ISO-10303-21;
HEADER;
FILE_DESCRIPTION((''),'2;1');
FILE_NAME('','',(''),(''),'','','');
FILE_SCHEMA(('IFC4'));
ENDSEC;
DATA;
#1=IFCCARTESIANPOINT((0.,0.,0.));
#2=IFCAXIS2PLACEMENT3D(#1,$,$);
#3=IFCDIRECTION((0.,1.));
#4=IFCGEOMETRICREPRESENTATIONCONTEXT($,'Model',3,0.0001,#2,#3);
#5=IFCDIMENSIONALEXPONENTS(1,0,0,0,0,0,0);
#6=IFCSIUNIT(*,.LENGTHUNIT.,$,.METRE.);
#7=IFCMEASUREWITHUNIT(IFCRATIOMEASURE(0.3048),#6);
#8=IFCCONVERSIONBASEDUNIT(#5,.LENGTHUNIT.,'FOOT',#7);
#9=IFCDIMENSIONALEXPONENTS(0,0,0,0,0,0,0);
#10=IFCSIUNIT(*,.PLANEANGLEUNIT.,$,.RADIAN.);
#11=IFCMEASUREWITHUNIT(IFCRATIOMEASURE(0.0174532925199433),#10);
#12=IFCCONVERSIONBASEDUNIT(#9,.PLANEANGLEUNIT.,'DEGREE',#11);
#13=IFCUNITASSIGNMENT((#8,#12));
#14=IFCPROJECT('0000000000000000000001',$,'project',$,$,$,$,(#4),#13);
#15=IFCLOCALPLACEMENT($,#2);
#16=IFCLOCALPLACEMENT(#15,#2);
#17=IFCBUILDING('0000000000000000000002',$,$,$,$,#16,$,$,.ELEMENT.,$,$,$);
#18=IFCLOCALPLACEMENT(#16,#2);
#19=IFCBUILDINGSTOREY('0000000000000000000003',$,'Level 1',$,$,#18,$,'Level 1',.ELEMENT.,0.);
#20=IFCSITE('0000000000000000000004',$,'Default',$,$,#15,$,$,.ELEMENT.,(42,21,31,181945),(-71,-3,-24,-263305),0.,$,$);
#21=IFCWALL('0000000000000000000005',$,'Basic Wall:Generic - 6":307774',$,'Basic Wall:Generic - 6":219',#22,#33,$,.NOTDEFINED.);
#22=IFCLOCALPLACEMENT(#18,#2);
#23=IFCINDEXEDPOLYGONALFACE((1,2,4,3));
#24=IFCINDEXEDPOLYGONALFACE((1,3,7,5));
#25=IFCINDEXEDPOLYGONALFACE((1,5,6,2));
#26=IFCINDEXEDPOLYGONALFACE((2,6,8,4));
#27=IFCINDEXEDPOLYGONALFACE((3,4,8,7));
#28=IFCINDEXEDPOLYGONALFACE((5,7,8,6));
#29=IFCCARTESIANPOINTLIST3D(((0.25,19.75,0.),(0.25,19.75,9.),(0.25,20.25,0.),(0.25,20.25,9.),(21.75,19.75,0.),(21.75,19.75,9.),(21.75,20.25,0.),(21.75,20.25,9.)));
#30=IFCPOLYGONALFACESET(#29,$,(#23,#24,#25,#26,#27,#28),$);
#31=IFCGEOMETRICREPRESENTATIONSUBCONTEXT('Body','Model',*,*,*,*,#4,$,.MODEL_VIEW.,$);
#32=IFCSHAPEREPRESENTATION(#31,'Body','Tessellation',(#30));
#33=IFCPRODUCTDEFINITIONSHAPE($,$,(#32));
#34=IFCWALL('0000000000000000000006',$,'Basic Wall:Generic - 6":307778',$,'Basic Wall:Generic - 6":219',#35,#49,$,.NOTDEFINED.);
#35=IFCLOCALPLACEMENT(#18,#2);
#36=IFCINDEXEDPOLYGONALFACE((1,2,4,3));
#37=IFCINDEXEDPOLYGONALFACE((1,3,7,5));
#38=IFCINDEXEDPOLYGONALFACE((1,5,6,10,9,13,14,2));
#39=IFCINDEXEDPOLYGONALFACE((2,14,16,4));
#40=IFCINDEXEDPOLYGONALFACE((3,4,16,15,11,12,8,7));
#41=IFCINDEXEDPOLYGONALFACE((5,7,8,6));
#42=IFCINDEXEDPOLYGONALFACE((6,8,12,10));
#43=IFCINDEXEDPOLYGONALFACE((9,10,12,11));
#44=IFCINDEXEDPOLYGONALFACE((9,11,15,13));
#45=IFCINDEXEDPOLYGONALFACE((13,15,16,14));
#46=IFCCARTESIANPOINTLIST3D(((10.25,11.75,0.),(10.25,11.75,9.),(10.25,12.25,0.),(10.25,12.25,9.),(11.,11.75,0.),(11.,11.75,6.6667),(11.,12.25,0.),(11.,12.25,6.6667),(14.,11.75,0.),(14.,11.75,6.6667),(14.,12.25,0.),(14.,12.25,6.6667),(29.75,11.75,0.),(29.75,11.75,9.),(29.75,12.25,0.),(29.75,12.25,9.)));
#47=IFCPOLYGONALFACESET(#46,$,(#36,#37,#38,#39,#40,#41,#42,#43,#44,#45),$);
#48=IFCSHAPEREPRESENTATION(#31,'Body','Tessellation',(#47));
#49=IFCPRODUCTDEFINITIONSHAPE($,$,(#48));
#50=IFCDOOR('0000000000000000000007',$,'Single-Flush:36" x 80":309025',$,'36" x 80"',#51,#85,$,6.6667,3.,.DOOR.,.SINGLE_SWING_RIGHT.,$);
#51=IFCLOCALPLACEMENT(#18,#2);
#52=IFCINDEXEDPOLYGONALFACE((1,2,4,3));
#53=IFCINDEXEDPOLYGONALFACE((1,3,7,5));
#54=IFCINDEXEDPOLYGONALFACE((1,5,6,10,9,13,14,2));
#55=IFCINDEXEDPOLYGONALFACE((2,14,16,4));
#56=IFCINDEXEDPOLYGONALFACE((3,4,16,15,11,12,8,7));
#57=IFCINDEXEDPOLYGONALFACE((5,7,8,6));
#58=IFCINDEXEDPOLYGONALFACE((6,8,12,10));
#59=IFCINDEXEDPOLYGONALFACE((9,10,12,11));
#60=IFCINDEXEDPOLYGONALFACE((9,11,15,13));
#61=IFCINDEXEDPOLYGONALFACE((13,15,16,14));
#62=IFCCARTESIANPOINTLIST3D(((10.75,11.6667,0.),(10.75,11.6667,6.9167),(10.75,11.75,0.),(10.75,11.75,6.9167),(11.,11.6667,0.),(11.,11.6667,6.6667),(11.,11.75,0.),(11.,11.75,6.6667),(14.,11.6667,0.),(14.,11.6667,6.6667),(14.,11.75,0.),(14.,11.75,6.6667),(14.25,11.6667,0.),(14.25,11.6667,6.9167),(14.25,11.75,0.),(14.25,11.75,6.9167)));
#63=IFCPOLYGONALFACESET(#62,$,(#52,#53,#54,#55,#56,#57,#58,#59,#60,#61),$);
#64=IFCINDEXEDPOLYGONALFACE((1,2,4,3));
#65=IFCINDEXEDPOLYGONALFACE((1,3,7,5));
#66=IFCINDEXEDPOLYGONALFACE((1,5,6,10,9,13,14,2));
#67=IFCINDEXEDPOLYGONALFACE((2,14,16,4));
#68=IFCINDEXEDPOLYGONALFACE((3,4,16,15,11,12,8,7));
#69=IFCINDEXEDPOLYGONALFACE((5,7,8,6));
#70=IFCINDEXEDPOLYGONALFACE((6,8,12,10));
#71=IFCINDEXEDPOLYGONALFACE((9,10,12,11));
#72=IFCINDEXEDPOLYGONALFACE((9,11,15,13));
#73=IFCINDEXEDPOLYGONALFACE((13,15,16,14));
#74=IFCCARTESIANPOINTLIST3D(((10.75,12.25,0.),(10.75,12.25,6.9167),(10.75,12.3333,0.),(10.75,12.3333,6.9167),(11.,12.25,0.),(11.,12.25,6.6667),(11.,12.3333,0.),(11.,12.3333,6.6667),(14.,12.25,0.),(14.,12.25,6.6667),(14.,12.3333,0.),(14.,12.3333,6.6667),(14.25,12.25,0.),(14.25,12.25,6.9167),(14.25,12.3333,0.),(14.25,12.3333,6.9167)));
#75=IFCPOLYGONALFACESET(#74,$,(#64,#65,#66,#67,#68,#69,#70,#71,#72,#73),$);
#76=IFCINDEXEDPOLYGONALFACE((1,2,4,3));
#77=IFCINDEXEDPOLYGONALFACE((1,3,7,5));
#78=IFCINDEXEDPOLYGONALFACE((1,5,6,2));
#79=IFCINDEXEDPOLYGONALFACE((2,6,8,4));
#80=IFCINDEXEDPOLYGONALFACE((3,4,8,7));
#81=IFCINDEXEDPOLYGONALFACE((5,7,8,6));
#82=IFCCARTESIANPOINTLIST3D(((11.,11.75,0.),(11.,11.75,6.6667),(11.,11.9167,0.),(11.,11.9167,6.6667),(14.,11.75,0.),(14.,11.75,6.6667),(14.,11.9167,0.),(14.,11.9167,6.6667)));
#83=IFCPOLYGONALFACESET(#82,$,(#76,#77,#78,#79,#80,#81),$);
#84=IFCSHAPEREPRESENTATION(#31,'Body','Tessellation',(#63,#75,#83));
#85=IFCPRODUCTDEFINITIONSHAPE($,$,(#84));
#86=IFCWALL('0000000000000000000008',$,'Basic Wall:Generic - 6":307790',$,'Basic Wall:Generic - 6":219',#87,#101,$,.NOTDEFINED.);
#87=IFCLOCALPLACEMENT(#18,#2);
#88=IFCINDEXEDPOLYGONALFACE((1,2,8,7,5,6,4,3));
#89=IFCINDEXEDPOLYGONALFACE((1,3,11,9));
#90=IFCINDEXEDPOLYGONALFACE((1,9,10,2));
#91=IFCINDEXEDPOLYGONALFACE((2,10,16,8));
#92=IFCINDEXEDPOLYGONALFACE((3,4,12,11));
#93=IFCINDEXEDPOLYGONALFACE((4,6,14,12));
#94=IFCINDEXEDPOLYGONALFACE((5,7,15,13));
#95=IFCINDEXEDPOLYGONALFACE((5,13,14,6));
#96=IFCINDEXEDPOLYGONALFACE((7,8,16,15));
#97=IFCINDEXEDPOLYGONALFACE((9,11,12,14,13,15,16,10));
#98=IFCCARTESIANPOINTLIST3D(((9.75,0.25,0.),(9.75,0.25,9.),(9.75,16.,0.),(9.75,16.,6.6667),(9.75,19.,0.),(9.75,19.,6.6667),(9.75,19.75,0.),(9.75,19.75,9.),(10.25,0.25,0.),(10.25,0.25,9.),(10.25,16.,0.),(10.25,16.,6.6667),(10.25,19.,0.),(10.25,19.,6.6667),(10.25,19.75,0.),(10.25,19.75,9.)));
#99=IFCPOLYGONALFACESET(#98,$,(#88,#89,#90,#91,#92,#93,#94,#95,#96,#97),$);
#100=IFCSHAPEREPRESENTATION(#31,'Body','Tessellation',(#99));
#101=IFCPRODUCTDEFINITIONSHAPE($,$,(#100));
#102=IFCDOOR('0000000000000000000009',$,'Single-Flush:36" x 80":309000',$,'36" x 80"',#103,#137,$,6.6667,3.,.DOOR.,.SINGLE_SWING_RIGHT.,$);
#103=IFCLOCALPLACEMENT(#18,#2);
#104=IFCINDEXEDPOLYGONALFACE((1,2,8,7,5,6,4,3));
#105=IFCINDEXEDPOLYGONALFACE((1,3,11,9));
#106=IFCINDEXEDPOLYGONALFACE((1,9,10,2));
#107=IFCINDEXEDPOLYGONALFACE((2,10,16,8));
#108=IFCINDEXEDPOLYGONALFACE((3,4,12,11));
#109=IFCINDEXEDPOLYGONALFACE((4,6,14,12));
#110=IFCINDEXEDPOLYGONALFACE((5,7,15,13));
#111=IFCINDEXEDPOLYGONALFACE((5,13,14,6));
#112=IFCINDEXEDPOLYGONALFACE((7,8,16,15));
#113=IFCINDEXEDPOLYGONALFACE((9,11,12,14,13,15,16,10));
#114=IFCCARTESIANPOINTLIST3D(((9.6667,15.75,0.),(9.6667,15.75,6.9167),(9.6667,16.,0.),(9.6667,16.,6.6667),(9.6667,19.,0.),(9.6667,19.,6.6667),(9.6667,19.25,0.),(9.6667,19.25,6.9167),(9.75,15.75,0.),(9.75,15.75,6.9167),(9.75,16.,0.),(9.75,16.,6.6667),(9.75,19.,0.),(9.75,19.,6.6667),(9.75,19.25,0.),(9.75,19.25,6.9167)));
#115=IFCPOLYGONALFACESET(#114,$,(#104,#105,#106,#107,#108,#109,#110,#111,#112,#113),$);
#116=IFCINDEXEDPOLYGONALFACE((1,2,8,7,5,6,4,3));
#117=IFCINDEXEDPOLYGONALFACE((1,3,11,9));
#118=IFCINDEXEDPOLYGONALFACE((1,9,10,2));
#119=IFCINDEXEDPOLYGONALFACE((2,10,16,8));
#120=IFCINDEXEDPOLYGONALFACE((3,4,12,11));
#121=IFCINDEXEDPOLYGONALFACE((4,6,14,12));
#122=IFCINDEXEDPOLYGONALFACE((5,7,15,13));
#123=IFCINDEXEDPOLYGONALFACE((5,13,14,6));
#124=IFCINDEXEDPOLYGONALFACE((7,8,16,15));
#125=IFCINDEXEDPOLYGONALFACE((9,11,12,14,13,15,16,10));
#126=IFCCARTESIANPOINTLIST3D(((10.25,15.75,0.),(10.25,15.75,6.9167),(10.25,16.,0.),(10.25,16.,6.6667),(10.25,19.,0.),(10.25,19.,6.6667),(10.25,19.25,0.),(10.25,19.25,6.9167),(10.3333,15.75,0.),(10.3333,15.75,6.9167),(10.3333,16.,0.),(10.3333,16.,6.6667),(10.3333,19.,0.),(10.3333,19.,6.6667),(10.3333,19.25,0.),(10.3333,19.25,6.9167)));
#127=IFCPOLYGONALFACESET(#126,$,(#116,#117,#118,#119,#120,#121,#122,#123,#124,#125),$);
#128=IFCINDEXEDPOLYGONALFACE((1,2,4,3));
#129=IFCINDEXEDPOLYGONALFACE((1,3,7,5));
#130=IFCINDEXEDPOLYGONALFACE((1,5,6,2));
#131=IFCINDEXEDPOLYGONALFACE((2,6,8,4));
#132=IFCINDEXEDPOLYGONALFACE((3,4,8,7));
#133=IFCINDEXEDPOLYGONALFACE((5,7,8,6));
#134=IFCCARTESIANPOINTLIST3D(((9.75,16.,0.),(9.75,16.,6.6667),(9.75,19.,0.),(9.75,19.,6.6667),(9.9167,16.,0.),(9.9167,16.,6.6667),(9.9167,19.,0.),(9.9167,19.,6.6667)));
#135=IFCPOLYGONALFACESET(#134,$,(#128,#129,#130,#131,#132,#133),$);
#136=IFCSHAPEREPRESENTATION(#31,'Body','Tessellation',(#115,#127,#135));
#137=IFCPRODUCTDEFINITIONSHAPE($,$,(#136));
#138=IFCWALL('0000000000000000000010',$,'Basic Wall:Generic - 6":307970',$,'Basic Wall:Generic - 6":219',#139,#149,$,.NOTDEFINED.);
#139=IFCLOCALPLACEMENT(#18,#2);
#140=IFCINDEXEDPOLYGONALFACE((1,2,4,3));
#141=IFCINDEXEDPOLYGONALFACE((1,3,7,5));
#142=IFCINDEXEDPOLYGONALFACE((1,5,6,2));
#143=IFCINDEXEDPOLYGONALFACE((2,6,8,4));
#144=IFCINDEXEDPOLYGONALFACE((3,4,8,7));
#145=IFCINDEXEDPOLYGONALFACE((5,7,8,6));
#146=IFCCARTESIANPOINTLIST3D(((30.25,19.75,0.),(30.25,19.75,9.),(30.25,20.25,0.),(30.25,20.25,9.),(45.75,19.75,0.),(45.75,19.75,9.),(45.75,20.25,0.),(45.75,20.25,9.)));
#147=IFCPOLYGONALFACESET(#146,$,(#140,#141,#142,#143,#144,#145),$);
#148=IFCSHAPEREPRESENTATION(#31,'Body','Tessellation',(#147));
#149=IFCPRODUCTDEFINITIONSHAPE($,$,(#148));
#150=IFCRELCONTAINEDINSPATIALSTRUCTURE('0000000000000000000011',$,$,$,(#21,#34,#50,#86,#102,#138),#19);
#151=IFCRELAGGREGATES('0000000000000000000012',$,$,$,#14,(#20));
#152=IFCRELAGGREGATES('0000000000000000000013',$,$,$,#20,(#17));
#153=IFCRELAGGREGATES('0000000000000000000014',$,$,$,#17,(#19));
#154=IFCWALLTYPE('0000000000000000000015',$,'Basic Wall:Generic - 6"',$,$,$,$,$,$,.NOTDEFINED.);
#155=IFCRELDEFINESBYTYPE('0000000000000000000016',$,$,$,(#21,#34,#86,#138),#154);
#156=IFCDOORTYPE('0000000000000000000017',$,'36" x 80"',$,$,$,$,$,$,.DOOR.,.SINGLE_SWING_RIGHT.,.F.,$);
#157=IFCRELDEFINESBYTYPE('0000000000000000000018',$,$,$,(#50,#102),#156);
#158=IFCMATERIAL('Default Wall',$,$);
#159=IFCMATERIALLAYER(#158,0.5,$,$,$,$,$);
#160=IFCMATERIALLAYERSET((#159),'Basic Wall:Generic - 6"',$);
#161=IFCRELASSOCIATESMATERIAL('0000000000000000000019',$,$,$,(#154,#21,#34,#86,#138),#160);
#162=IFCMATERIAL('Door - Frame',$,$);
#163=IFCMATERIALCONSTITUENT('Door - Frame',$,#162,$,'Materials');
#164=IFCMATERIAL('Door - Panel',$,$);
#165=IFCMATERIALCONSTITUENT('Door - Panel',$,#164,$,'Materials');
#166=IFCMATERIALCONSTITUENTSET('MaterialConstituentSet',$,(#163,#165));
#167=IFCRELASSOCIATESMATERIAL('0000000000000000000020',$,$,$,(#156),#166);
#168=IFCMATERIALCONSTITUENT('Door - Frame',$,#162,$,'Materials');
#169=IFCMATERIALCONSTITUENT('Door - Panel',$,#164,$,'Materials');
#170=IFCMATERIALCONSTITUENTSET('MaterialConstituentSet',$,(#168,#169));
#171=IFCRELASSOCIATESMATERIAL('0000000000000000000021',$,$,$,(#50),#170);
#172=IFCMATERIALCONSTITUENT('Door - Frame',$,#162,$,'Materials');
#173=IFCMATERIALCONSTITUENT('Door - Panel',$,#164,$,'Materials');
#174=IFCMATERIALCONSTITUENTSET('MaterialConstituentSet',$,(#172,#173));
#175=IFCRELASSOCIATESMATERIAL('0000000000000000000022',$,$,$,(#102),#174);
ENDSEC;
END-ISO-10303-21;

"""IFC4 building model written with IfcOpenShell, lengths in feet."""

from ifc_helpers import new_model, entity, si_unit, converted_unit, direction, frame, frame_2d, origin, origin_2d_with_axis, place, context, subcontext, project, spatial, polyline, rectangle, outline, extrude, clip, bounded_halfspace, source, transform, mapped, material, layer, layer_set, layer_usage, constituent, constituent_set, type_object, type_shapes, element, fill, save


model = new_model("IFC4")

# Units and contexts
model_context = context("Model", 3, precision=0.0001, world=origin(), true_north=direction((0.0, 1.0)))
body_context = subcontext(model_context, "Body", "Model", "MODEL_VIEW")
ifc_project = project(units=[converted_unit("LENGTHUNIT", "FOOT", entity("IfcRatioMeasure", 0.3048), si_unit("LENGTHUNIT", "METRE"), dimensions=[1, 0, 0, 0, 0, 0, 0]), converted_unit("PLANEANGLEUNIT", "DEGREE", entity("IfcRatioMeasure", 0.0174532925199433), si_unit("PLANEANGLEUNIT", "RADIAN"), dimensions=[0, 0, 0, 0, 0, 0, 0])], contexts=[model_context])

# Site, building, storey
site_placement = place(None, origin())
site = spatial("IfcSite", under=ifc_project, at=site_placement, Name="Default", CompositionType="ELEMENT", RefLatitude=(42, 21, 31, 181945), RefLongitude=(-71, -3, -24, -263305), RefElevation=0.0)
building_placement = place(site_placement, origin())
building = spatial("IfcBuilding", under=site, at=building_placement, CompositionType="ELEMENT")
storey_placement = place(building_placement, origin())
storey = spatial("IfcBuildingStorey", under=building, at=storey_placement, Name="Level 1", LongName="Level 1", CompositionType="ELEMENT", Elevation=0.0)

# Shared definitions
ifc_material_1 = material(Name="Default Wall")
ifc_layer = layer(ifc_material_1, 0.5)
ifc_layer_set = layer_set([ifc_layer], Name="Basic Wall:Generic - 6\"")
wall_type = type_object("IfcWallType", Name="Basic Wall:Generic - 6\"", PredefinedType="NOTDEFINED", material=ifc_layer_set)

# Wall
ifc_layer_usage_1 = layer_usage(ifc_layer_set, "AXIS2", "NEGATIVE", 0.25)
wall_1_placement = place(storey_placement, frame((0.25, 20.0, 0.0)))
element("IfcWall", 1, at=wall_1_placement, inside=storey, type_object=wall_type, material=ifc_layer_usage_1, Name="Basic Wall:Generic - 6\":307774", ObjectType="Basic Wall:Generic - 6\":219", PredefinedType="NOTDEFINED", context=body_context, shape_type="Clipping", body=[
    clip(clip(extrude(rectangle(XDim=21.5, YDim=0.5, at=frame_2d((10.75, 0.0), x_axis=(-1.0, 0.0))), origin(), (0.0, 0.0, 1.0), 9.0), bounded_halfspace(frame((21.5, -0.25, 9.0), z_axis=(0.0, 0.0, -1.0), x_axis=(0.0, -1.0, 0.0)), True, frame((21.5, -0.25, 9.0)), polyline([(0.0, 0.0), (0.0, 0.5), (-12.0, 0.5), (-12.0, 0.0), (-11.5, 0.0), (0.0, 0.0)]))), bounded_halfspace(frame((0.0, -0.25, 9.0), z_axis=(0.0, 0.0, -1.0), x_axis=(0.0, -1.0, 0.0)), True, frame((0.0, -0.25, 9.0)), polyline([(0.0, 0.0), (9.5, 0.0), (9.5, 0.5), (0.0, 0.5), (0.0, 0.0)]))),
])

# Walls, openings, doors
ifc_layer_usage_2 = layer_usage(ifc_layer_set, "AXIS2", "NEGATIVE", 0.25)
wall_2_placement = place(storey_placement, frame((10.25, 12.0, 0.0)))
wall_2 = element("IfcWall", 2, at=wall_2_placement, inside=storey, type_object=wall_type, material=ifc_layer_usage_2, Name="Basic Wall:Generic - 6\":307778", ObjectType="Basic Wall:Generic - 6\":219", PredefinedType="NOTDEFINED", context=body_context, shape_type="Clipping", body=[
    clip(extrude(rectangle(XDim=19.5, YDim=0.5, at=frame_2d((9.75, 0.0), x_axis=(-1.0, 0.0))), origin(), (0.0, 0.0, 1.0), 9.0), bounded_halfspace(frame((0.0, -0.25, 9.0), z_axis=(0.0, 0.0, -1.0), x_axis=(0.0, -1.0, 0.0)), True, frame((0.0, -0.25, 9.0)), polyline([(0.0, 0.0), (19.5, 0.0), (19.5, 0.5), (0.0, 0.5), (0.0, 0.0)]))),
])
opening_1_placement = place(wall_2_placement, frame((3.75, 0.25, 0.0)))
opening_1 = element("IfcOpeningElement", 3, at=opening_1_placement, cuts=wall_2, ObjectType="Opening", PredefinedType="OPENING", context=body_context, shape_type="SweptSolid", body=[
    extrude(rectangle(XDim=3.0, YDim=6.6667, at=frame_2d((3.3333, 1.5), x_axis=(0.0, 1.0))), frame((0.0, 0.0, 0.0), z_axis=(0.0, -1.0, 0.0), x_axis=(0.0, 0.0, 1.0)), (0.0, 0.0, 1.0), 0.5),
])
ifc_material_2 = material(Name="Door - Frame")
ifc_constituent_1 = constituent(ifc_material_2, Name="Door - Frame", Category="Materials")
ifc_material_3 = material(Name="Door - Panel")
ifc_constituent_2 = constituent(ifc_material_3, Name="Door - Panel", Category="Materials")
ifc_constituent_set_1 = constituent_set(constituents=[ifc_constituent_1, ifc_constituent_2], Name="MaterialConstituentSet")
ifc_constituent_3 = constituent(ifc_material_2, Name="Door - Frame", Category="Materials")
ifc_constituent_4 = constituent(ifc_material_3, Name="Door - Panel", Category="Materials")
ifc_constituent_set_2 = constituent_set(constituents=[ifc_constituent_3, ifc_constituent_4], Name="MaterialConstituentSet")
door_type = type_object("IfcDoorType", Name="36\" x 80\"", OperationType="SINGLE_SWING_RIGHT", ParameterTakesPrecedence=False, PredefinedType="DOOR", material=ifc_constituent_set_2)
shared_shape_1 = source(origin(), body_context, "Body", "SweptSolid", [
    extrude(outline(polyline([(-1.75, -3.5208), (1.75, -3.5208), (1.75, 3.3958), (1.5, 3.3958), (1.5, -3.2708), (-1.5, -3.2708), (-1.5, 3.3958), (-1.75, 3.3958), (-1.75, -3.5208)])), frame((1.5, 0.5, 3.3958), z_axis=(0.0, 1.0, 0.0), x_axis=(1.0, 0.0, 0.0)), (0.0, 0.0, 1.0), 0.0833),
    extrude(outline(polyline([(-3.5208, -1.75), (3.3958, -1.75), (3.3958, -1.5), (-3.2708, -1.5), (-3.2708, 1.5), (3.3958, 1.5), (3.3958, 1.75), (-3.5208, 1.75), (-3.5208, -1.75)])), frame((1.5, -0.0833, 3.3958), z_axis=(0.0, 1.0, 0.0), x_axis=(0.0, 0.0, -1.0)), (0.0, 0.0, 1.0), 0.0833),
    extrude(rectangle(XDim=0.1667, YDim=3.0, at=origin_2d_with_axis()), frame((1.5, 0.4167, 0.0), z_axis=(0.0, 0.0, 1.0), x_axis=(0.0, 1.0, 0.0)), (0.0, 0.0, 1.0), 6.6667),
])
type_shapes(door_type, [shared_shape_1])
door_1_placement = place(opening_1_placement, frame((0.0, 0.0, 0.0), z_axis=(0.0, 0.0, 1.0), x_axis=(-1.0, 0.0, 0.0)))
door_1 = element("IfcDoor", 4, at=door_1_placement, inside=storey, type_object=door_type, material=ifc_constituent_set_1, Name="Single-Flush:36\" x 80\":309025", ObjectType="36\" x 80\"", OperationType="SINGLE_SWING_RIGHT", OverallHeight=6.6667, OverallWidth=3.0, PredefinedType="DOOR", context=body_context, shape_type="MappedRepresentation", body=[
    mapped(shared_shape_1, transform((0.0, 0.0, 0.0), scale=1.0)),
])
fill(opening_1, door_1)
ifc_layer_usage_3 = layer_usage(ifc_layer_set, "AXIS2", "NEGATIVE", 0.25)
wall_3_placement = place(storey_placement, frame((10.0, 19.75, 0.0), z_axis=(0.0, 0.0, 1.0), x_axis=(0.0, -1.0, 0.0)))
wall_3 = element("IfcWall", 5, at=wall_3_placement, inside=storey, type_object=wall_type, material=ifc_layer_usage_3, Name="Basic Wall:Generic - 6\":307790", ObjectType="Basic Wall:Generic - 6\":219", PredefinedType="NOTDEFINED", context=body_context, shape_type="Clipping", body=[
    clip(clip(extrude(rectangle(XDim=19.5, YDim=0.5, at=frame_2d((9.75, 0.0), x_axis=(-1.0, 0.0))), origin(), (0.0, 0.0, 1.0), 9.0), bounded_halfspace(frame((8.0, -0.25, 9.0), z_axis=(0.0, 0.0, -1.0), x_axis=(0.0, 1.0, 0.0)), True, frame((8.0, -0.25, 9.0)), polyline([(0.0, 0.0), (11.5, 0.0), (11.5, 0.5), (0.0, 0.5), (0.0, 0.0)]))), bounded_halfspace(frame((8.0, -0.25, 9.0), z_axis=(0.0, 0.0, -1.0), x_axis=(1.0, 0.0, 0.0)), True, frame((8.0, -0.25, 9.0)), polyline([(0.0, 0.0), (0.0, 0.5), (-0.5, 0.5), (-8.0, 0.5), (-8.0, 0.0), (0.0, 0.0)]))),
])
opening_2_placement = place(wall_3_placement, frame((3.75, 0.25, 0.0)))
opening_2 = element("IfcOpeningElement", 6, at=opening_2_placement, cuts=wall_3, ObjectType="Opening", PredefinedType="OPENING", context=body_context, shape_type="SweptSolid", body=[
    extrude(rectangle(XDim=3.0, YDim=6.6667, at=frame_2d((3.3333, 1.5), x_axis=(0.0, 1.0))), frame((0.0, 0.0, 0.0), z_axis=(0.0, -1.0, 0.0), x_axis=(0.0, 0.0, 1.0)), (0.0, 0.0, 1.0), 0.5),
])
ifc_constituent_5 = constituent(ifc_material_2, Name="Door - Frame", Category="Materials")
ifc_constituent_6 = constituent(ifc_material_3, Name="Door - Panel", Category="Materials")
ifc_constituent_set_3 = constituent_set(constituents=[ifc_constituent_5, ifc_constituent_6], Name="MaterialConstituentSet")
door_2_placement = place(opening_2_placement, frame((0.0, 0.0, 0.0), z_axis=(0.0, 0.0, 1.0), x_axis=(-1.0, 0.0, 0.0)))
door_2 = element("IfcDoor", 7, at=door_2_placement, inside=storey, type_object=door_type, material=ifc_constituent_set_3, Name="Single-Flush:36\" x 80\":309000", ObjectType="36\" x 80\"", OperationType="SINGLE_SWING_RIGHT", OverallHeight=6.6667, OverallWidth=3.0, PredefinedType="DOOR", context=body_context, shape_type="MappedRepresentation", body=[
    mapped(shared_shape_1, transform((0.0, 0.0, 0.0), scale=1.0)),
])
fill(opening_2, door_2)

# Wall
ifc_layer_usage_4 = layer_usage(ifc_layer_set, "AXIS2", "NEGATIVE", 0.25)
wall_4_placement = place(storey_placement, frame((30.25, 20.0, 0.0)))
element("IfcWall", 8, at=wall_4_placement, inside=storey, type_object=wall_type, material=ifc_layer_usage_4, Name="Basic Wall:Generic - 6\":307970", ObjectType="Basic Wall:Generic - 6\":219", PredefinedType="NOTDEFINED", context=body_context, shape_type="Clipping", body=[
    clip(extrude(rectangle(XDim=15.5, YDim=0.5, at=frame_2d((7.75, 0.0), x_axis=(-1.0, 0.0))), origin(), (0.0, 0.0, 1.0), 9.0), bounded_halfspace(frame((0.0, -0.25, 9.0), z_axis=(0.0, 0.0, -1.0), x_axis=(1.0, 0.0, 0.0)), True, frame((0.0, -0.25, 9.0)), polyline([(0.0, 0.0), (15.5, 0.0), (15.5, 0.5), (0.0, 0.5), (0.0, 0.0)]))),
])

save(model, "model.ifc")
